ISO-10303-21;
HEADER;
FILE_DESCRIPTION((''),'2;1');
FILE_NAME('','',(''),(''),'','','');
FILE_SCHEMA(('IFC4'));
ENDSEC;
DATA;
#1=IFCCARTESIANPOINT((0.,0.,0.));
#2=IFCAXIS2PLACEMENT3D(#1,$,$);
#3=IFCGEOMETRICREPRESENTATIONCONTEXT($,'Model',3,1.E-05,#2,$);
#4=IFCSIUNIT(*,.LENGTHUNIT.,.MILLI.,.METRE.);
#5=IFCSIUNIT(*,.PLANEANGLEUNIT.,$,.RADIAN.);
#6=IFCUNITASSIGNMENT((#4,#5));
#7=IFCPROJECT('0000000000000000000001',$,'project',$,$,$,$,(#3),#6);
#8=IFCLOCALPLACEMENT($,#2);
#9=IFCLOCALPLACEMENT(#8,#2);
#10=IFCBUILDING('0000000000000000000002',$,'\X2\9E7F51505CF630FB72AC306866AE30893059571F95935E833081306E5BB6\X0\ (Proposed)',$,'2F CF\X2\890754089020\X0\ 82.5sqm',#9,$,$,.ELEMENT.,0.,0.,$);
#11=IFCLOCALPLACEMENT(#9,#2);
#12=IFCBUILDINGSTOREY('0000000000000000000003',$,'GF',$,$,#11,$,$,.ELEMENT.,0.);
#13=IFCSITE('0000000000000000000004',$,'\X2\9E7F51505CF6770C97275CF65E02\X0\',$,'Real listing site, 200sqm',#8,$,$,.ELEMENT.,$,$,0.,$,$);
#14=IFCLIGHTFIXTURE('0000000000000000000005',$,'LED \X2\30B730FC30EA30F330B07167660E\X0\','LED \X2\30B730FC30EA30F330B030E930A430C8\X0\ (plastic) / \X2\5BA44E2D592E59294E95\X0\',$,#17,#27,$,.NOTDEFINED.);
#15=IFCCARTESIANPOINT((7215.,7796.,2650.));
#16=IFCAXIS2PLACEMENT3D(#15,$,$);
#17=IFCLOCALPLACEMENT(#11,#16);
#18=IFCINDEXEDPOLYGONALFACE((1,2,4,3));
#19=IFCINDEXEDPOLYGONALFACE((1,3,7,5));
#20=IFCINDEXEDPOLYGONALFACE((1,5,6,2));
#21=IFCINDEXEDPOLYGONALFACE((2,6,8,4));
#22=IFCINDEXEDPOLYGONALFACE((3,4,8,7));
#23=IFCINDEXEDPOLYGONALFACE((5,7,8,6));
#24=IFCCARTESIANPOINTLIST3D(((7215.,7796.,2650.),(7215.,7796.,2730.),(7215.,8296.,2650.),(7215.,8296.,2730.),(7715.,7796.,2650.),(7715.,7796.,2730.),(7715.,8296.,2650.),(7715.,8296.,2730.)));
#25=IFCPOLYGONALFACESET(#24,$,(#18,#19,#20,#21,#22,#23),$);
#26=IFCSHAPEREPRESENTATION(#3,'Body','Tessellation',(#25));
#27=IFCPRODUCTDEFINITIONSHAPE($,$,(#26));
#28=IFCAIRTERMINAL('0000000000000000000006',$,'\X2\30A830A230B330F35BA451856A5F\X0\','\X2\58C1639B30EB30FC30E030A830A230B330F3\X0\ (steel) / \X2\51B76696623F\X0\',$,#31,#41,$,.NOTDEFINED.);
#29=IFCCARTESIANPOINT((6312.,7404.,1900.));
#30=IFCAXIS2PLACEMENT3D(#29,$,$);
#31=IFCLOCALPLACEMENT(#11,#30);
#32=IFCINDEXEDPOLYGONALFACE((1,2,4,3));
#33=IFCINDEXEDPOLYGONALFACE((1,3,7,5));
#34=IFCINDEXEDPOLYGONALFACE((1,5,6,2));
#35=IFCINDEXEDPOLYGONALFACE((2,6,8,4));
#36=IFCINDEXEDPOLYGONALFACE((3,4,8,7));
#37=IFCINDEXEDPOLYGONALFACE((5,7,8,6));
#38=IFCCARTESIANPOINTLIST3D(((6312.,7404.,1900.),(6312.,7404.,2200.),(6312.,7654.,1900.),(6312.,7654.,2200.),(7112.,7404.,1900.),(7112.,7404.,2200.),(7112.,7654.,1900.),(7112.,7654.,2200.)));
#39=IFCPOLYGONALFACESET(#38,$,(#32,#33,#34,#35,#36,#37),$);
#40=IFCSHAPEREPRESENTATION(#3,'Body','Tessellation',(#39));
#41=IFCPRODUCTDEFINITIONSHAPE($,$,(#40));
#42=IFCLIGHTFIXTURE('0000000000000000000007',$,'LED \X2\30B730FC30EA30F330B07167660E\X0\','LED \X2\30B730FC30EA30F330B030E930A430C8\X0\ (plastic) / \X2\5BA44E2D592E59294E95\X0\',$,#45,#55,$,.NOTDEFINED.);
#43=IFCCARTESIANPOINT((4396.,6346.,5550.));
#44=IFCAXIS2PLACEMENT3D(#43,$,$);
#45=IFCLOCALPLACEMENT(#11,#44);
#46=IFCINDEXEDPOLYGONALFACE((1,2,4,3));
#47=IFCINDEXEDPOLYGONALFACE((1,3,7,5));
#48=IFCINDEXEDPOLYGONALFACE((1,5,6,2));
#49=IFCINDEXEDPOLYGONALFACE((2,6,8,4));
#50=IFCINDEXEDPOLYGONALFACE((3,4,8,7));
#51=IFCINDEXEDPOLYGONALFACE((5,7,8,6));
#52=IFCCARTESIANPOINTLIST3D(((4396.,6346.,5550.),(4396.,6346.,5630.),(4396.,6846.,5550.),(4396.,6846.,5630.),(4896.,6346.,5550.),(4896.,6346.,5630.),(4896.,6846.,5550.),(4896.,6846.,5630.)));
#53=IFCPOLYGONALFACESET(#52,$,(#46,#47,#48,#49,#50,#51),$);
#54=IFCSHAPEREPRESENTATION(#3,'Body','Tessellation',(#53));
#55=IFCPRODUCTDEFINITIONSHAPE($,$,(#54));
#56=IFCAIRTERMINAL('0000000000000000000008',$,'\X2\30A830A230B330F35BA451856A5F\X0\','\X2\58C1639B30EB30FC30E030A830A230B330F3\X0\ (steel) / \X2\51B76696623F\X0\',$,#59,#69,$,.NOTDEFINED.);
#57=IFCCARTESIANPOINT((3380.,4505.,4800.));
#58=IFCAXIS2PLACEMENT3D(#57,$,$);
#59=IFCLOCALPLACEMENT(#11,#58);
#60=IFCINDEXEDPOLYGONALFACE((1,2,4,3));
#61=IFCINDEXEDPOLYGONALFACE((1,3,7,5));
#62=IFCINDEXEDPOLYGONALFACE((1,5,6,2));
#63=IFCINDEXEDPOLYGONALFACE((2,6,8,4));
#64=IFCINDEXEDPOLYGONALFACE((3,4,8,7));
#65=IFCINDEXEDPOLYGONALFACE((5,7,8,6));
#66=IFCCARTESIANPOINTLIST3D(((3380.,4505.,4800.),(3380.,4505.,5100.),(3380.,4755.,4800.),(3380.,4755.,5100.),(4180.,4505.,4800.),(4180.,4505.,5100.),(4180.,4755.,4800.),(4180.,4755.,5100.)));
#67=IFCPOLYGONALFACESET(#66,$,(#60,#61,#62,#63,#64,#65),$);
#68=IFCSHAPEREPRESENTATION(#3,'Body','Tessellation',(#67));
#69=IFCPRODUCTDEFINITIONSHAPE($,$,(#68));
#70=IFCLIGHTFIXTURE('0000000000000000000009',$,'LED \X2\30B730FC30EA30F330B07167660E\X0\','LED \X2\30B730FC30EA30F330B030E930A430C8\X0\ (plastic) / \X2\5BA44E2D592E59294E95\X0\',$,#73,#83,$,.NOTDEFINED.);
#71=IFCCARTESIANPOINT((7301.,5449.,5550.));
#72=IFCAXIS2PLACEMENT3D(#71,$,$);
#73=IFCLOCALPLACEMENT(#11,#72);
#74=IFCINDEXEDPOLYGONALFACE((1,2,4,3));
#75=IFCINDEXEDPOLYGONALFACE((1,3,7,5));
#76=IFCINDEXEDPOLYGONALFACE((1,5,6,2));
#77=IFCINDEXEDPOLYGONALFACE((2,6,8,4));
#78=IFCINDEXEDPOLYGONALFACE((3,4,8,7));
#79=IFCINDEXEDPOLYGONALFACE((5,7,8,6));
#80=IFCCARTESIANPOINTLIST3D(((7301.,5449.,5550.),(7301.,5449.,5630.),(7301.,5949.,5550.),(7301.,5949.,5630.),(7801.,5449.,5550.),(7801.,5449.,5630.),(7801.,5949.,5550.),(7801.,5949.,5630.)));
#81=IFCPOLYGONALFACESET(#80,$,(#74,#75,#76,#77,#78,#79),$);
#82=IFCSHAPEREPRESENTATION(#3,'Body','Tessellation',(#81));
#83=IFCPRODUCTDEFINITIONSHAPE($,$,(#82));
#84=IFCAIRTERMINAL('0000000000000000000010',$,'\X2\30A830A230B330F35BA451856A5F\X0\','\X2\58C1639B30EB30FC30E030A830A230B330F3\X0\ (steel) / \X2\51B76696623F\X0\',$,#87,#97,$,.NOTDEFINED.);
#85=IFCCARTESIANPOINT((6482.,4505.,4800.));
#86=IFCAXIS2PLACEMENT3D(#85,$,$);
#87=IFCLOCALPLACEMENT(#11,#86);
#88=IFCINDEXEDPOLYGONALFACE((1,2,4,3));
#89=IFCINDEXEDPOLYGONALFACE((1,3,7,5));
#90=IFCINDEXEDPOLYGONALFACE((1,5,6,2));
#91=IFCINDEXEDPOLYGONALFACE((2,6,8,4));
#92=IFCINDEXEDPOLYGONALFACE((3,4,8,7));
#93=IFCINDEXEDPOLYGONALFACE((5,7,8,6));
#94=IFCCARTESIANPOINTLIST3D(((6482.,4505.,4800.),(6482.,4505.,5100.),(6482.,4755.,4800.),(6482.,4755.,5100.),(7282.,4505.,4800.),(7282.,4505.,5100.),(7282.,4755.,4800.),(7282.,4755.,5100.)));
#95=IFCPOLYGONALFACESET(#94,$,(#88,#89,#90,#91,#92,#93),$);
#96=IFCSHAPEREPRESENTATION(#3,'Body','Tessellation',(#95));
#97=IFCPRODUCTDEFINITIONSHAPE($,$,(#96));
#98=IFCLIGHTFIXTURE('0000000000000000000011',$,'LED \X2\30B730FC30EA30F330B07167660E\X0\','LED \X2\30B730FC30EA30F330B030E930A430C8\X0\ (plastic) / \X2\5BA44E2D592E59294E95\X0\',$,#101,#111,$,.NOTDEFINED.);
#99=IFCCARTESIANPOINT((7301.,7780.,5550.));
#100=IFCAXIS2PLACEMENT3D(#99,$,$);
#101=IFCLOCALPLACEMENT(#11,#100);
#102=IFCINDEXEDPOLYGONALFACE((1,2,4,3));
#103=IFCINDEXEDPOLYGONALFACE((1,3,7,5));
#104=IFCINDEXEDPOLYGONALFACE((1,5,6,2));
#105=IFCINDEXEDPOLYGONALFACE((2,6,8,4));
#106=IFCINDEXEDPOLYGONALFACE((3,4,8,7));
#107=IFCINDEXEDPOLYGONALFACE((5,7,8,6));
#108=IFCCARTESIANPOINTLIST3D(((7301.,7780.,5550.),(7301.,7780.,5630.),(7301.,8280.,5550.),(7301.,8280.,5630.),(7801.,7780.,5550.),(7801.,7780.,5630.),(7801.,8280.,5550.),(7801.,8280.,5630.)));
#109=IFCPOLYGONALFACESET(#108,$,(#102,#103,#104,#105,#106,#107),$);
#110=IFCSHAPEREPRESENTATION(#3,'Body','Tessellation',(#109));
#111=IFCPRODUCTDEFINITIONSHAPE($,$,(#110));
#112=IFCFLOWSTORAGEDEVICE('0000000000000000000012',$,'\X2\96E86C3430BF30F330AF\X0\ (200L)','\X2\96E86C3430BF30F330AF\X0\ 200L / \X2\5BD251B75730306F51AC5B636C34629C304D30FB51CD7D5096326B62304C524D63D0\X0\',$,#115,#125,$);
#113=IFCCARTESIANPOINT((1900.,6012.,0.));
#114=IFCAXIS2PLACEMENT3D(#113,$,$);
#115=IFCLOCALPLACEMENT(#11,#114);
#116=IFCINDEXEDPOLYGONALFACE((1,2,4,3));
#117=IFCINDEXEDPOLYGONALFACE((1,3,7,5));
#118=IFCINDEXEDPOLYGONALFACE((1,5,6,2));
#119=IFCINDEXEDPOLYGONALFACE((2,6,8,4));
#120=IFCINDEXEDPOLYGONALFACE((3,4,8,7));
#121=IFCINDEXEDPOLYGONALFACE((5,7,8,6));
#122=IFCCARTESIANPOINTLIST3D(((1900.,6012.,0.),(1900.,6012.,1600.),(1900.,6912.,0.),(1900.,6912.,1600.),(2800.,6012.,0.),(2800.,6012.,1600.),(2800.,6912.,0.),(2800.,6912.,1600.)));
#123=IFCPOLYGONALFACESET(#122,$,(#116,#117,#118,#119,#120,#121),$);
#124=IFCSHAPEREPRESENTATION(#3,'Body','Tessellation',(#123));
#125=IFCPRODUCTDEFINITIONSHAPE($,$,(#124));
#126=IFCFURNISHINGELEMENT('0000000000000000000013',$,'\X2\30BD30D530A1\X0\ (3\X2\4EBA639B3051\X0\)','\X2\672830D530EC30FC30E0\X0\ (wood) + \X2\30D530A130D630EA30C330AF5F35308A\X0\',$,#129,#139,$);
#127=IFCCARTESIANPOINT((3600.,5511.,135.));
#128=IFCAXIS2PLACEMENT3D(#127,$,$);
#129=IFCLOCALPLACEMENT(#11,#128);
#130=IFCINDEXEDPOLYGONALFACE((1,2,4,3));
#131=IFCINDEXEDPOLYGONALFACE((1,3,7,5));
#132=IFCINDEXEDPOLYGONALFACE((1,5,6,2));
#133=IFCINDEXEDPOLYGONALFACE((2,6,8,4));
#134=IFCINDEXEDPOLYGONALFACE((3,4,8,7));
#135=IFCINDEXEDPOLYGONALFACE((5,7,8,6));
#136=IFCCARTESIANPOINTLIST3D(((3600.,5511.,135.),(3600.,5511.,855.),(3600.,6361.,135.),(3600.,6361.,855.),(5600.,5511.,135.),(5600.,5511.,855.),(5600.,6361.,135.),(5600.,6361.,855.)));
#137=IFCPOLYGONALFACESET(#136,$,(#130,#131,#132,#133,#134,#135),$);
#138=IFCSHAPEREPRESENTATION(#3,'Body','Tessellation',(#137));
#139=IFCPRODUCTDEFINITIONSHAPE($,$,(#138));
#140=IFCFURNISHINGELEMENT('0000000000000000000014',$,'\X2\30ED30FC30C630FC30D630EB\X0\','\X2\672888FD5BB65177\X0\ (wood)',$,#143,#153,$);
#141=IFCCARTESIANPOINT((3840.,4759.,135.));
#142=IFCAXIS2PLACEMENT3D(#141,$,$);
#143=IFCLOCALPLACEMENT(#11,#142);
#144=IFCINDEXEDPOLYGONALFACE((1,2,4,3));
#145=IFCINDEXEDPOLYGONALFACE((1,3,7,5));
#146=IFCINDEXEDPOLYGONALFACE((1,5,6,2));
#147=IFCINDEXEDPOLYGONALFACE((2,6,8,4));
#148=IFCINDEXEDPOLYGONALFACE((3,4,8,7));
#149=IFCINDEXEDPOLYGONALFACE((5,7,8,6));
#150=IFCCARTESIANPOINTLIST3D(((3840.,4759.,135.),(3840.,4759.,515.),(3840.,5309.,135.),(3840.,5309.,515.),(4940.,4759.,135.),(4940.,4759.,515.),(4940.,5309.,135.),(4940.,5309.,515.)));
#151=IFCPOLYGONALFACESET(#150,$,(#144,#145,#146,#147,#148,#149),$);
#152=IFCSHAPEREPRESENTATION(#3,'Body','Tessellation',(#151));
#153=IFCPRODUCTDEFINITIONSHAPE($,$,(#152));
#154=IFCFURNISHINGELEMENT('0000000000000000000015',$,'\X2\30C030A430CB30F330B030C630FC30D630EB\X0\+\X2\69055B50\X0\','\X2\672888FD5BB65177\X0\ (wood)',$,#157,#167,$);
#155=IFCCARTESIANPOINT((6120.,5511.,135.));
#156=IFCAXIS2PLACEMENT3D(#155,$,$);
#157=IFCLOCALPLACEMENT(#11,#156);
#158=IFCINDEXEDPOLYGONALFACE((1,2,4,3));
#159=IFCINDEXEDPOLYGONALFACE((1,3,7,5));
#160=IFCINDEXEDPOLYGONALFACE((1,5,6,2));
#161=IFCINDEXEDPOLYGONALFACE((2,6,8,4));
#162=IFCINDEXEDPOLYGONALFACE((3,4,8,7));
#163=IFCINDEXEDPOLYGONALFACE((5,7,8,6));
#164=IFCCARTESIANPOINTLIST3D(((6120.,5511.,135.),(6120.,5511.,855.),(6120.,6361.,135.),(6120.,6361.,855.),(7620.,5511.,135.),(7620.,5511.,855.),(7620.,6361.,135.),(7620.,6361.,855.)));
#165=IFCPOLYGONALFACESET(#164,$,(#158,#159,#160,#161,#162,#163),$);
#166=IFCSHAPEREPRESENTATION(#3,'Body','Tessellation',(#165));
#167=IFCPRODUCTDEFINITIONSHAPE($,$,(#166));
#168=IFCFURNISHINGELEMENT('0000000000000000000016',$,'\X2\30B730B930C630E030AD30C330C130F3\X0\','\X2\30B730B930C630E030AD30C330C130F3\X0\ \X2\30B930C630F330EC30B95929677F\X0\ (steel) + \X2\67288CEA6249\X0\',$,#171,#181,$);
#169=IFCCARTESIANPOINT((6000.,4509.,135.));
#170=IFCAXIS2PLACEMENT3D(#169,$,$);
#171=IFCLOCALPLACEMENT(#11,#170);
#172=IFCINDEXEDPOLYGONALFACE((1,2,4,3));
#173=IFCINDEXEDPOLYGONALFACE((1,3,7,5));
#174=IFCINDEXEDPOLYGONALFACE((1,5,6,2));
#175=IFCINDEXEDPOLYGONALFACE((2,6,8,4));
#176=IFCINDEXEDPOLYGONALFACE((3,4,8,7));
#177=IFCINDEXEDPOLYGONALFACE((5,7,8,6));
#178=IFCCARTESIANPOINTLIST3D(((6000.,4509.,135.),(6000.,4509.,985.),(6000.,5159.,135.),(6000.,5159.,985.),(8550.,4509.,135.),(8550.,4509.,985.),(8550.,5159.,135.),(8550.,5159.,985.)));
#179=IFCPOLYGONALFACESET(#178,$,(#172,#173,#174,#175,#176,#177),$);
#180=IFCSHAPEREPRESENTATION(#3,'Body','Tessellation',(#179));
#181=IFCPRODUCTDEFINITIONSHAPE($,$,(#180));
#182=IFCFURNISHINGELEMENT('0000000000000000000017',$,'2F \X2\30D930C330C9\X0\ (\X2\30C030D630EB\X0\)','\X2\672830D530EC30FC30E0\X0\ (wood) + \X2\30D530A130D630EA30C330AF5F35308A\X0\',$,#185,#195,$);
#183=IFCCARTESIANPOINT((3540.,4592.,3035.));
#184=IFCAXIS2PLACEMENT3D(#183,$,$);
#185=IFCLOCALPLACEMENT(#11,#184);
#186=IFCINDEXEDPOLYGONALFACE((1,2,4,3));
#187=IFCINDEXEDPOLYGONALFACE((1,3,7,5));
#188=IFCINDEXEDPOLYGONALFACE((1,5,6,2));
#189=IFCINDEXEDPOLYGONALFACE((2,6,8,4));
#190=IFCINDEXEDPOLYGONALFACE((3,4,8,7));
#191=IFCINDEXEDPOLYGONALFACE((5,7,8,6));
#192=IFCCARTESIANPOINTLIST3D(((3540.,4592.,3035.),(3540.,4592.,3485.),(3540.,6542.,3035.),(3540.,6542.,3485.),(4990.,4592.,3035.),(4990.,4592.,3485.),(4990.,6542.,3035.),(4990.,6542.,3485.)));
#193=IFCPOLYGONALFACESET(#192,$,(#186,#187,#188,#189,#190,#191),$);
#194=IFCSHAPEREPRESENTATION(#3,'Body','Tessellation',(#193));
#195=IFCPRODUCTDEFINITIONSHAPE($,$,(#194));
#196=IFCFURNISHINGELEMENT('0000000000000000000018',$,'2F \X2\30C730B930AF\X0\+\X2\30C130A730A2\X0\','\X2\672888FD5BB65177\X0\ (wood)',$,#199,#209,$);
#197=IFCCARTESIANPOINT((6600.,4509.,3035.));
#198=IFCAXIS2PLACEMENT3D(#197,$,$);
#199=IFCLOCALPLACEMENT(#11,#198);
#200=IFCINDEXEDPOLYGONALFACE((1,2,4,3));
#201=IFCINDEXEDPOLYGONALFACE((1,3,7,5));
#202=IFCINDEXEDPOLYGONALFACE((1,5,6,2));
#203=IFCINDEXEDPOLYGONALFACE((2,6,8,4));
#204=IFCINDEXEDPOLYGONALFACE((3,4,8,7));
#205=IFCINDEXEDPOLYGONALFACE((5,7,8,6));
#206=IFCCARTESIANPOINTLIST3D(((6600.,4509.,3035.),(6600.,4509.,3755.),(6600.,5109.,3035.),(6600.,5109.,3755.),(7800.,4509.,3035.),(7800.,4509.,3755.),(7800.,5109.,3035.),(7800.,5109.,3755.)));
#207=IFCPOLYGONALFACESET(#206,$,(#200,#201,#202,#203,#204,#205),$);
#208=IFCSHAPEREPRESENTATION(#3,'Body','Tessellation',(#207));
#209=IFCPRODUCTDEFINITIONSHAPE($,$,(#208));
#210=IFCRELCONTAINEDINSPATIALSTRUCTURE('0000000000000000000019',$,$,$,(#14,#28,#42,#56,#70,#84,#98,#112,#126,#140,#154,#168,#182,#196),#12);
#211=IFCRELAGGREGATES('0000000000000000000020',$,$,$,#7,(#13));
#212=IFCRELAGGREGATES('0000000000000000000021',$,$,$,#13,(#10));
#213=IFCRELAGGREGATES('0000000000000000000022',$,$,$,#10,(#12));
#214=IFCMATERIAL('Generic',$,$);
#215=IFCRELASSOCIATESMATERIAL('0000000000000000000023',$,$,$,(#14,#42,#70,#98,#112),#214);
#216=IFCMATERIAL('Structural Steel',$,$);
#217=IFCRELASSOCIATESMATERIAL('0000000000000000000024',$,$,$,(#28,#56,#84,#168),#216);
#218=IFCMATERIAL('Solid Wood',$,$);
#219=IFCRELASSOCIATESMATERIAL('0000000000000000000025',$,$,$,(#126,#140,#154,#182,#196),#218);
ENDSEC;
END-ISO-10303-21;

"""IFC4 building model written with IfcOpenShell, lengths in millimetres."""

from ifc_helpers import new_model, si_unit, frame, frame_2d, origin, place, context, project, spatial, rectangle, extrude, material, element, save


model = new_model("IFC4")

# Units and contexts
model_context = context("Model", 3, precision=1e-05, world=origin())
ifc_project = project(units=[si_unit("LENGTHUNIT", "METRE", prefix="MILLI"), si_unit("PLANEANGLEUNIT", "RADIAN")], contexts=[model_context])

# Site, building, storey
site_placement = place(None, origin())
site = spatial("IfcSite", under=ifc_project, at=site_placement, Name="鹿児島県霧島市", ObjectType="Real listing site, 200sqm", CompositionType="ELEMENT", RefElevation=0.0)
building_placement = place(site_placement, origin())
building = spatial("IfcBuilding", under=site, at=building_placement, Name="鹿児島・犬と暮らす土間広めの家 (Proposed)", ObjectType="2F CF複合造 82.5sqm", CompositionType="ELEMENT", ElevationOfRefHeight=0.0, ElevationOfTerrain=0.0)
storey_placement = place(building_placement, origin())
storey = spatial("IfcBuildingStorey", under=building, at=storey_placement, Name="GF", CompositionType="ELEMENT", Elevation=0.0)

# Shared definitions
ifc_material_1 = material(Name="Solid Wood")

# Shared definitions
ifc_material_2 = material(Name="Structural Steel")

# Shared definitions
ifc_material_3 = material(Name="Generic")

# Light fixture
light_fixture_1_placement = place(storey_placement, frame((7215.0, 7796.0, 2650.0)))
element("IfcLightFixture", 1, at=light_fixture_1_placement, inside=storey, material=ifc_material_3, Name="LED シーリング照明", Description="LED シーリングライト (plastic) / 室中央天井", PredefinedType="NOTDEFINED", context=model_context, shape_type="SweptSolid", body=[
    extrude(rectangle(XDim=500.0, YDim=500.0, at=frame_2d((250.0, 250.0))), frame((7215.0, 7796.0, 2650.0)), (0.0, 0.0, 1.0), 80.0),
])

# Air terminal
air_terminal_1_placement = place(storey_placement, frame((6312.0, 7404.0, 1900.0)))
element("IfcAirTerminal", 2, at=air_terminal_1_placement, inside=storey, material=ifc_material_2, Name="エアコン室内機", Description="壁掛ルームエアコン (steel) / 冷暖房", PredefinedType="NOTDEFINED", context=model_context, shape_type="SweptSolid", body=[
    extrude(rectangle(XDim=800.0, YDim=250.0, at=frame_2d((400.0, 125.0))), frame((6312.0, 7404.0, 1900.0)), (0.0, 0.0, 1.0), 300.0),
])

# Light fixture
light_fixture_2_placement = place(storey_placement, frame((4396.0, 6346.0, 5550.0)))
element("IfcLightFixture", 3, at=light_fixture_2_placement, inside=storey, material=ifc_material_3, Name="LED シーリング照明", Description="LED シーリングライト (plastic) / 室中央天井", PredefinedType="NOTDEFINED", context=model_context, shape_type="SweptSolid", body=[
    extrude(rectangle(XDim=500.0, YDim=500.0, at=frame_2d((250.0, 250.0))), frame((4396.0, 6346.0, 5550.0)), (0.0, 0.0, 1.0), 80.0),
])

# Air terminal
air_terminal_2_placement = place(storey_placement, frame((3380.0, 4505.0, 4800.0)))
element("IfcAirTerminal", 4, at=air_terminal_2_placement, inside=storey, material=ifc_material_2, Name="エアコン室内機", Description="壁掛ルームエアコン (steel) / 冷暖房", PredefinedType="NOTDEFINED", context=model_context, shape_type="SweptSolid", body=[
    extrude(rectangle(XDim=800.0, YDim=250.0, at=frame_2d((400.0, 125.0))), frame((3380.0, 4505.0, 4800.0)), (0.0, 0.0, 1.0), 300.0),
])

# Light fixture
light_fixture_3_placement = place(storey_placement, frame((7301.0, 5449.0, 5550.0)))
element("IfcLightFixture", 5, at=light_fixture_3_placement, inside=storey, material=ifc_material_3, Name="LED シーリング照明", Description="LED シーリングライト (plastic) / 室中央天井", PredefinedType="NOTDEFINED", context=model_context, shape_type="SweptSolid", body=[
    extrude(rectangle(XDim=500.0, YDim=500.0, at=frame_2d((250.0, 250.0))), frame((7301.0, 5449.0, 5550.0)), (0.0, 0.0, 1.0), 80.0),
])

# Air terminal
air_terminal_3_placement = place(storey_placement, frame((6482.0, 4505.0, 4800.0)))
element("IfcAirTerminal", 6, at=air_terminal_3_placement, inside=storey, material=ifc_material_2, Name="エアコン室内機", Description="壁掛ルームエアコン (steel) / 冷暖房", PredefinedType="NOTDEFINED", context=model_context, shape_type="SweptSolid", body=[
    extrude(rectangle(XDim=800.0, YDim=250.0, at=frame_2d((400.0, 125.0))), frame((6482.0, 4505.0, 4800.0)), (0.0, 0.0, 1.0), 300.0),
])

# Light fixture
light_fixture_4_placement = place(storey_placement, frame((7301.0, 7780.0, 5550.0)))
element("IfcLightFixture", 7, at=light_fixture_4_placement, inside=storey, material=ifc_material_3, Name="LED シーリング照明", Description="LED シーリングライト (plastic) / 室中央天井", PredefinedType="NOTDEFINED", context=model_context, shape_type="SweptSolid", body=[
    extrude(rectangle(XDim=500.0, YDim=500.0, at=frame_2d((250.0, 250.0))), frame((7301.0, 7780.0, 5550.0)), (0.0, 0.0, 1.0), 80.0),
])

# Flow storage device
flow_storage_device_1_placement = place(storey_placement, frame((1900.0, 6012.0, 0.0)))
element("IfcFlowStorageDevice", 8, at=flow_storage_device_1_placement, inside=storey, material=ifc_material_3, Name="雨水タンク (200L)", Description="雨水タンク 200L / 寒冷地は冬季水抜き・凍結防止が前提", context=model_context, shape_type="SweptSolid", body=[
    extrude(rectangle(XDim=900.0, YDim=900.0, at=frame_2d((450.0, 450.0))), frame((1900.0, 6012.0, 0.0)), (0.0, 0.0, 1.0), 1600.0),
])

# Furnishing elements
furnishing_1_placement = place(storey_placement, frame((3600.0, 5511.0, 135.0)))
element("IfcFurnishingElement", 9, at=furnishing_1_placement, inside=storey, material=ifc_material_1, Name="ソファ (3人掛け)", Description="木フレーム (wood) + ファブリック張り", context=model_context, shape_type="SweptSolid", body=[
    extrude(rectangle(XDim=2000.0, YDim=850.0, at=frame_2d((1000.0, 425.0))), frame((3600.0, 5511.0, 135.0)), (0.0, 0.0, 1.0), 720.0),
])
furnishing_2_placement = place(storey_placement, frame((3840.0, 4759.0, 135.0)))
element("IfcFurnishingElement", 10, at=furnishing_2_placement, inside=storey, material=ifc_material_1, Name="ローテーブル", Description="木製家具 (wood)", context=model_context, shape_type="SweptSolid", body=[
    extrude(rectangle(XDim=1100.0, YDim=550.0, at=frame_2d((550.0, 275.0))), frame((3840.0, 4759.0, 135.0)), (0.0, 0.0, 1.0), 380.0),
])
furnishing_3_placement = place(storey_placement, frame((6120.0, 5511.0, 135.0)))
element("IfcFurnishingElement", 11, at=furnishing_3_placement, inside=storey, material=ifc_material_1, Name="ダイニングテーブル+椅子", Description="木製家具 (wood)", context=model_context, shape_type="SweptSolid", body=[
    extrude(rectangle(XDim=1500.0, YDim=850.0, at=frame_2d((750.0, 425.0))), frame((6120.0, 5511.0, 135.0)), (0.0, 0.0, 1.0), 720.0),
])
furnishing_4_placement = place(storey_placement, frame((6000.0, 4509.0, 135.0)))
element("IfcFurnishingElement", 12, at=furnishing_4_placement, inside=storey, material=ifc_material_2, Name="システムキッチン", Description="システムキッチン ステンレス天板 (steel) + 木質扉", context=model_context, shape_type="SweptSolid", body=[
    extrude(rectangle(XDim=2550.0, YDim=650.0, at=frame_2d((1275.0, 325.0))), frame((6000.0, 4509.0, 135.0)), (0.0, 0.0, 1.0), 850.0),
])
furnishing_5_placement = place(storey_placement, frame((3540.0, 4592.0, 3035.0)))
element("IfcFurnishingElement", 13, at=furnishing_5_placement, inside=storey, material=ifc_material_1, Name="2F ベッド (ダブル)", Description="木フレーム (wood) + ファブリック張り", context=model_context, shape_type="SweptSolid", body=[
    extrude(rectangle(XDim=1450.0, YDim=1950.0, at=frame_2d((725.0, 975.0))), frame((3540.0, 4592.0, 3035.0)), (0.0, 0.0, 1.0), 450.0),
])
furnishing_6_placement = place(storey_placement, frame((6600.0, 4509.0, 3035.0)))
element("IfcFurnishingElement", 14, at=furnishing_6_placement, inside=storey, material=ifc_material_1, Name="2F デスク+チェア", Description="木製家具 (wood)", context=model_context, shape_type="SweptSolid", body=[
    extrude(rectangle(XDim=1200.0, YDim=600.0, at=frame_2d((600.0, 300.0))), frame((6600.0, 4509.0, 3035.0)), (0.0, 0.0, 1.0), 720.0),
])

save(model, "model.ifc")
